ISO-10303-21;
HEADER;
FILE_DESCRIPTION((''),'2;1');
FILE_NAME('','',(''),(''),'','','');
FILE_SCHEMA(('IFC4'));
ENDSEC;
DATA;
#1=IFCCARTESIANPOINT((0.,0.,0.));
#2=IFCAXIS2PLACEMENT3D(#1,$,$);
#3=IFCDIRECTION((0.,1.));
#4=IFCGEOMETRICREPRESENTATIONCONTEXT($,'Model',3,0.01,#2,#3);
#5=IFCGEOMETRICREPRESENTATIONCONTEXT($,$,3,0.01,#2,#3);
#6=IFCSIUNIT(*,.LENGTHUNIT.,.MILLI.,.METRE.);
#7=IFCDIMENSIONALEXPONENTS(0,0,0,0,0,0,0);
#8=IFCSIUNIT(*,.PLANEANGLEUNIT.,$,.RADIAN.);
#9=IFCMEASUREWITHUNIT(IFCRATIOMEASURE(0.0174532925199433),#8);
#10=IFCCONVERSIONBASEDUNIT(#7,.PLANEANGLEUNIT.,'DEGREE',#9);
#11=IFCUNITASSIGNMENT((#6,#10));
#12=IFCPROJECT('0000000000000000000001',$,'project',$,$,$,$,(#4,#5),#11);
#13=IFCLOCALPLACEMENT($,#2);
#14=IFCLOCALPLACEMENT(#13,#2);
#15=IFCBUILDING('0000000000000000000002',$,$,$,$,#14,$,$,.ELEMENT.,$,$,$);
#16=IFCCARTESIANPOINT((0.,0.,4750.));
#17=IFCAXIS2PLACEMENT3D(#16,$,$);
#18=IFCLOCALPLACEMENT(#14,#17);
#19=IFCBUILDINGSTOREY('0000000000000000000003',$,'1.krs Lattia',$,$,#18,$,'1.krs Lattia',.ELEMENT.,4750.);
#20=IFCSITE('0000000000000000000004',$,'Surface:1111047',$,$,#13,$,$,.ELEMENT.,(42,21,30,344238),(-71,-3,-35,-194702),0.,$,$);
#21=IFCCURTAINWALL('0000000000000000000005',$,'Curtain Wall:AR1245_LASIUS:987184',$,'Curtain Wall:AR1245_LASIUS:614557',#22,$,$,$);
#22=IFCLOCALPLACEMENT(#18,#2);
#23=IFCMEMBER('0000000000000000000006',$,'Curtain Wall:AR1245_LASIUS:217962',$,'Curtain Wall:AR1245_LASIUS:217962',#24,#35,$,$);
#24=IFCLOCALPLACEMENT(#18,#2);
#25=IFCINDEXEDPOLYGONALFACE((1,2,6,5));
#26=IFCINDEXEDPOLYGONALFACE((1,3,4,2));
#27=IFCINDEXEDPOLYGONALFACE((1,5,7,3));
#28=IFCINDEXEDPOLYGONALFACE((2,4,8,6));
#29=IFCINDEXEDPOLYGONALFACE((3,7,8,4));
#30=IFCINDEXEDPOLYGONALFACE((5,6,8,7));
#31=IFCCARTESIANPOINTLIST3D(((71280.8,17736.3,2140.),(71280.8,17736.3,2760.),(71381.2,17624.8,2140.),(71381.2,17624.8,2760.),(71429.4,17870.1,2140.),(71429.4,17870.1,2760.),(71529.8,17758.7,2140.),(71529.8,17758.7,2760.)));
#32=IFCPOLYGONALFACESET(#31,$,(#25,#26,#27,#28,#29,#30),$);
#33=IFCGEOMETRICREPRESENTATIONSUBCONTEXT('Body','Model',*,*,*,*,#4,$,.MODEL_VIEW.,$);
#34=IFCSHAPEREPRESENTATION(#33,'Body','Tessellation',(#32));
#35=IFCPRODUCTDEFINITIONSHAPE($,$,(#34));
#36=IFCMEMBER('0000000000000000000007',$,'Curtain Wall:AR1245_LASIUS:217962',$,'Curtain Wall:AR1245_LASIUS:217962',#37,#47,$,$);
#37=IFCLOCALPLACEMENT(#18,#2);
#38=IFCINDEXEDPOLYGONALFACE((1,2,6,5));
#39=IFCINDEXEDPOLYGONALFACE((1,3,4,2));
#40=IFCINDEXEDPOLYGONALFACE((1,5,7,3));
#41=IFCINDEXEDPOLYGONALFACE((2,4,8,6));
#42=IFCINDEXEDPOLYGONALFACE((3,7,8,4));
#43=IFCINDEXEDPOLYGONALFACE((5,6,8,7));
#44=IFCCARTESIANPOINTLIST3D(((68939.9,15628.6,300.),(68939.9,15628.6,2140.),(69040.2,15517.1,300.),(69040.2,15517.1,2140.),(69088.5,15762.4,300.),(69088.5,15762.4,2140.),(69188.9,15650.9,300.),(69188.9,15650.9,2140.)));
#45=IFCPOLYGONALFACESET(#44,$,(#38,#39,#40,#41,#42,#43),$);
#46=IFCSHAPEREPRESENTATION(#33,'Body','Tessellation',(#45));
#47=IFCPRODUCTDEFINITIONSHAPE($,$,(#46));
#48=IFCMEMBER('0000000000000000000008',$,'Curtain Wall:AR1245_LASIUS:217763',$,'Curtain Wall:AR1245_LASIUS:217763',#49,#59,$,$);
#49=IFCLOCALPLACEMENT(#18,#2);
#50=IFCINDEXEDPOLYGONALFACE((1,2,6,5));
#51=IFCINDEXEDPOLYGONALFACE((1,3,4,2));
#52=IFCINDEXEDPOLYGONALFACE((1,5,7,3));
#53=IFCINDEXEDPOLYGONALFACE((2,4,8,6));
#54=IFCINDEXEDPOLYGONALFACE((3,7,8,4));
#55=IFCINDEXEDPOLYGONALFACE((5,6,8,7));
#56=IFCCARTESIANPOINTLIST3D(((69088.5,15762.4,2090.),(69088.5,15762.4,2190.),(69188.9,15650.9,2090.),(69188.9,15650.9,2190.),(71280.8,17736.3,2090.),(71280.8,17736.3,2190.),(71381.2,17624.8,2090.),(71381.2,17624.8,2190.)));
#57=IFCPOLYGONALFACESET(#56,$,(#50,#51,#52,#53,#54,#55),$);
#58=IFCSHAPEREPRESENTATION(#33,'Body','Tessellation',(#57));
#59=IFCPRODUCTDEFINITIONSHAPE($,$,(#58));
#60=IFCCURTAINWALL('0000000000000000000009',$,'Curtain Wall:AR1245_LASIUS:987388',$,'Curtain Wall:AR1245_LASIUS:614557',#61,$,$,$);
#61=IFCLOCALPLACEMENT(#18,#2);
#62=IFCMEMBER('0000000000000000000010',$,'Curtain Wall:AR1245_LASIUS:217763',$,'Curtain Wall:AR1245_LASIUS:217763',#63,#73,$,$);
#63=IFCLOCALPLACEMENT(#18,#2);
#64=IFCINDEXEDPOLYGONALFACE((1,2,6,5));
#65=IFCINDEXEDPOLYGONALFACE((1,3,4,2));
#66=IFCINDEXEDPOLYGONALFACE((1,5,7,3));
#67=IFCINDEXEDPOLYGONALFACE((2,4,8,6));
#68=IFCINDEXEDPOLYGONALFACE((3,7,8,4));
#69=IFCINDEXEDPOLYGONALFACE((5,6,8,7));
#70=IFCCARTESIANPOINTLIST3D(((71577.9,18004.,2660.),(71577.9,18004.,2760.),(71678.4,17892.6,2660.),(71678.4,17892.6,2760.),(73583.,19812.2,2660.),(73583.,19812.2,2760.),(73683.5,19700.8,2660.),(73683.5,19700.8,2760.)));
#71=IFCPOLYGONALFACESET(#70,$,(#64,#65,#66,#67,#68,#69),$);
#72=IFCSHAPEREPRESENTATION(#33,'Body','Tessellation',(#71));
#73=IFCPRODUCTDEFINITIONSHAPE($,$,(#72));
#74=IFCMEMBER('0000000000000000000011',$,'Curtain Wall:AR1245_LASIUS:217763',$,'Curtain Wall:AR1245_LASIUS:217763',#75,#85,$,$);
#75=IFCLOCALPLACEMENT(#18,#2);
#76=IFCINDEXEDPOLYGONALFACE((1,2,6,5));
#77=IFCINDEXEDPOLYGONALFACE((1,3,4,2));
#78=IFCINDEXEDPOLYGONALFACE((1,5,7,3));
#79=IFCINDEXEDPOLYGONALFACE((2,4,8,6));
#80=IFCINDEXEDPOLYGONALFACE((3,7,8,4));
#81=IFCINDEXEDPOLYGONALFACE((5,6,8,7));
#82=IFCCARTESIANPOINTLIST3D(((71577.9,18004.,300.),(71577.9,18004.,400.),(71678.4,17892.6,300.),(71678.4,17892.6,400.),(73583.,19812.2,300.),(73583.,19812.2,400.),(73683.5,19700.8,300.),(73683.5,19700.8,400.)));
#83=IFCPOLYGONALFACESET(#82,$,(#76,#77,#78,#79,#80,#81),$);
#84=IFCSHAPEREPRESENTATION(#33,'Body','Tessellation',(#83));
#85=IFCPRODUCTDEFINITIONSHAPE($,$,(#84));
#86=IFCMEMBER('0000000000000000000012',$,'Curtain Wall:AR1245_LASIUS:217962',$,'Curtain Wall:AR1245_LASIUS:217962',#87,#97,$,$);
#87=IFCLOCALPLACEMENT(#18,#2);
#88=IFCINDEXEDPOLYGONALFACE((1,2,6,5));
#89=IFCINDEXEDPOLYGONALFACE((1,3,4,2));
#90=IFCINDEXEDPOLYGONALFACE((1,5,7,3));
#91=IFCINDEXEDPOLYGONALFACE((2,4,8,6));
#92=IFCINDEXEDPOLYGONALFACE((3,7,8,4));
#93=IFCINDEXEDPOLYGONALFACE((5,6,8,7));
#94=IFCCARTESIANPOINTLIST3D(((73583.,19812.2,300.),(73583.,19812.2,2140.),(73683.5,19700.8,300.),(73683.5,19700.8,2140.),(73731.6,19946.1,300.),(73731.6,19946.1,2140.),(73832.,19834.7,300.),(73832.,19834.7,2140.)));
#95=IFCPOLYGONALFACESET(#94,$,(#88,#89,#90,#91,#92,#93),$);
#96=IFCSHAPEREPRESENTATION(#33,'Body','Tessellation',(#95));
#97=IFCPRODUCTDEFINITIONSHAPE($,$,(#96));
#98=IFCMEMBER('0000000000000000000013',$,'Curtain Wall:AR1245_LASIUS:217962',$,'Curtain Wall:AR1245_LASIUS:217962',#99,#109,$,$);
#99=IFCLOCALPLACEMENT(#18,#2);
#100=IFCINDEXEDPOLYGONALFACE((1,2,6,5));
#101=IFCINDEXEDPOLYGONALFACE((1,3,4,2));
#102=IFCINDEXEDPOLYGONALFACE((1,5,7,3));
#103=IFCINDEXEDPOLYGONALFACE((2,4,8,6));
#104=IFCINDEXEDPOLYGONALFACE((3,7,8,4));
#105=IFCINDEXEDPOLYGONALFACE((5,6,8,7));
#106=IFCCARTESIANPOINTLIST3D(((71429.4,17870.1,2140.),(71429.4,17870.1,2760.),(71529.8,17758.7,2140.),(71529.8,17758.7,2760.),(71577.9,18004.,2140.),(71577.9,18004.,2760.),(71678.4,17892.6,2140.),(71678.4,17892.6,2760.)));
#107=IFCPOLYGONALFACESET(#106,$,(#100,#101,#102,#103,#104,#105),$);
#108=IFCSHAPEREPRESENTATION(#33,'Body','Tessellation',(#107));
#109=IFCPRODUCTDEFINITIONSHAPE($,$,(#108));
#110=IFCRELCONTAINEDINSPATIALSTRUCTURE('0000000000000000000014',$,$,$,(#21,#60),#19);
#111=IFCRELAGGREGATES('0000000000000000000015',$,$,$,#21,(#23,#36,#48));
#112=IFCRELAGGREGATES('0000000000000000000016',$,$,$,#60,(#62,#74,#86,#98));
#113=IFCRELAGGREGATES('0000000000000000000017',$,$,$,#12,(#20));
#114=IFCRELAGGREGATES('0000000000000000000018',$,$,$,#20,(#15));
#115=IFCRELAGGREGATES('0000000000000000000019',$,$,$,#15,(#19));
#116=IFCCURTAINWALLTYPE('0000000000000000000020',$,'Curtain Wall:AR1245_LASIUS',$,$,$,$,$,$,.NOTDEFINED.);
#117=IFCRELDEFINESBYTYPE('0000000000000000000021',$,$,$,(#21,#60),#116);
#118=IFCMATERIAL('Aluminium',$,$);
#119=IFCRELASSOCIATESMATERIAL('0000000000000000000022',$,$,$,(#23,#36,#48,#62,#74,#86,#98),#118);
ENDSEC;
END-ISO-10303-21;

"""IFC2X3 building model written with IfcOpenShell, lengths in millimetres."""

from ifc_helpers import new_model, entity, si_unit, converted_unit, direction, frame, frame_2d, origin, place, context, subcontext, project, spatial, rectangle, extrude, material, type_object, element, aggregate, save


model = new_model("IFC2X3")

# Units and contexts
model_context = context("Model", 3, precision=0.01, world=origin(), true_north=direction((0.0, 1.0)))
context_of_model = context(None, 3, precision=0.01, world=origin(), true_north=direction((0.0, 1.0)))
body_context = subcontext(model_context, "Body", "Model", "MODEL_VIEW")
ifc_project = project(units=[si_unit("LENGTHUNIT", "METRE", prefix="MILLI"), converted_unit("PLANEANGLEUNIT", "DEGREE", entity("IfcRatioMeasure", 0.0174532925199433), si_unit("PLANEANGLEUNIT", "RADIAN"), dimensions=[0, 0, 0, 0, 0, 0, 0])], contexts=[model_context, context_of_model])

# Site, building, storey
site_placement = place(None, origin())
site = spatial("IfcSite", under=ifc_project, at=site_placement, Name="Surface:1111047", CompositionType="ELEMENT", RefLatitude=(42, 21, 30, 344238), RefLongitude=(-71, -3, -35, -194702), RefElevation=0.0)
building_placement = place(site_placement, origin())
building = spatial("IfcBuilding", under=site, at=building_placement, CompositionType="ELEMENT")
storey_placement = place(building_placement, frame((0.0, 0.0, 4750.0)))
storey = spatial("IfcBuildingStorey", under=building, at=storey_placement, Name="1.krs Lattia", LongName="1.krs Lattia", CompositionType="ELEMENT", Elevation=4750.0)

# Curtain walls, members
curtain_wall_type_1 = type_object("IfcCurtainWallType", Name="Curtain Wall:AR1245_LASIUS", PredefinedType="NOTDEFINED")
ifc_material_1 = material(Name="Aluminium")
curtain_wall_1_placement = place(storey_placement, frame((0.0, 0.0, -4750.0)))
curtain_wall_1 = element("IfcCurtainWall", 1, at=curtain_wall_1_placement, inside=storey, type_object=curtain_wall_type_1, Name="Curtain Wall:AR1245_LASIUS:987184", ObjectType="Curtain Wall:AR1245_LASIUS:614557")
member_1_placement = place(curtain_wall_1_placement, frame((0.0, 0.0, 4750.0)))
member_1 = element("IfcMember", 2, at=member_1_placement, material=ifc_material_1, Name="Curtain Wall:AR1245_LASIUS:217962", ObjectType="Curtain Wall:AR1245_LASIUS:217962", context=body_context, shape_type="SweptSolid", body=[
    extrude(rectangle(XDim=200.0, YDim=150.0, at=frame_2d((0.0, 0.0), x_axis=(1.0, 0.0))), frame((71405.3, 17747.5, 2140.0), z_axis=(0.0, 0.0, 1.0), x_axis=(0.743145, 0.669131, 0.0)), (0.0, 0.0, 1.0), 620.0),
])
member_2_placement = place(curtain_wall_1_placement, frame((0.0, 0.0, 4750.0)))
member_2 = element("IfcMember", 3, at=member_2_placement, material=ifc_material_1, Name="Curtain Wall:AR1245_LASIUS:217962", ObjectType="Curtain Wall:AR1245_LASIUS:217962", context=body_context, shape_type="SweptSolid", body=[
    extrude(rectangle(XDim=150.0, YDim=200.0, at=frame_2d((0.0, 0.0), x_axis=(1.0, 0.0))), frame((69064.4, 15639.7, 2140.0), z_axis=(0.0, 0.0, -1.0), x_axis=(0.669131, -0.743145, 0.0)), (0.0, 0.0, 1.0), 1840.0),
])
member_3_placement = place(curtain_wall_1_placement, frame((0.0, 0.0, 4750.0)))
member_3 = element("IfcMember", 4, at=member_3_placement, material=ifc_material_1, Name="Curtain Wall:AR1245_LASIUS:217763", ObjectType="Curtain Wall:AR1245_LASIUS:217763", context=body_context, shape_type="SweptSolid", body=[
    extrude(rectangle(XDim=100.0, YDim=150.0, at=frame_2d((0.0, 0.0), x_axis=(1.0, 0.0))), frame((71331.0, 17680.6, 2140.0), z_axis=(-0.743145, -0.669131, 0.0), x_axis=(0.0, 0.0, -1.0)), (0.0, 0.0, 1.0), 2950.0),
])
aggregate(curtain_wall_1, [member_1, member_2, member_3])
curtain_wall_2_placement = place(storey_placement, frame((0.0, 0.0, -4750.0)))
curtain_wall_2 = element("IfcCurtainWall", 5, at=curtain_wall_2_placement, inside=storey, type_object=curtain_wall_type_1, Name="Curtain Wall:AR1245_LASIUS:987388", ObjectType="Curtain Wall:AR1245_LASIUS:614557")
member_4_placement = place(curtain_wall_2_placement, frame((0.0, 0.0, 4750.0)))
member_4 = element("IfcMember", 6, at=member_4_placement, material=ifc_material_1, Name="Curtain Wall:AR1245_LASIUS:217763", ObjectType="Curtain Wall:AR1245_LASIUS:217763", context=body_context, shape_type="SweptSolid", body=[
    extrude(rectangle(XDim=100.0, YDim=150.0, at=frame_2d((0.0, 0.0), x_axis=(1.0, 0.0))), frame((73633.3, 19756.5, 2710.0), z_axis=(-0.742646, -0.669684, 0.0), x_axis=(0.0, 0.0, -1.0)), (0.0, 0.0, 1.0), 2700.0),
])
member_5_placement = place(curtain_wall_2_placement, frame((0.0, 0.0, 4750.0)))
member_5 = element("IfcMember", 7, at=member_5_placement, material=ifc_material_1, Name="Curtain Wall:AR1245_LASIUS:217763", ObjectType="Curtain Wall:AR1245_LASIUS:217763", context=body_context, shape_type="SweptSolid", body=[
    extrude(rectangle(XDim=100.0, YDim=150.0, at=frame_2d((0.0, 0.0), x_axis=(1.0, 0.0))), frame((71628.1, 17948.3, 350.0), z_axis=(0.742646, 0.669684, 0.0), x_axis=(0.0, 0.0, -1.0)), (0.0, 0.0, 1.0), 2700.0),
])
member_6_placement = place(curtain_wall_2_placement, frame((0.0, 0.0, 4750.0)))
member_6 = element("IfcMember", 8, at=member_6_placement, material=ifc_material_1, Name="Curtain Wall:AR1245_LASIUS:217962", ObjectType="Curtain Wall:AR1245_LASIUS:217962", context=body_context, shape_type="SweptSolid", body=[
    extrude(rectangle(XDim=200.0, YDim=150.0, at=frame_2d((0.0, 0.0), x_axis=(1.0, 0.0))), frame((73707.5, 19823.5, 300.0), z_axis=(0.0, 0.0, 1.0), x_axis=(0.742646, 0.669684, 0.0)), (0.0, 0.0, 1.0), 1840.0),
])
member_7_placement = place(curtain_wall_2_placement, frame((0.0, 0.0, 4750.0)))
member_7 = element("IfcMember", 9, at=member_7_placement, material=ifc_material_1, Name="Curtain Wall:AR1245_LASIUS:217962", ObjectType="Curtain Wall:AR1245_LASIUS:217962", context=body_context, shape_type="SweptSolid", body=[
    extrude(rectangle(XDim=150.0, YDim=200.0, at=frame_2d((0.0, 0.0), x_axis=(1.0, 0.0))), frame((71553.9, 17881.4, 2760.0), z_axis=(0.0, 0.0, -1.0), x_axis=(0.669684, -0.742646, 0.0)), (0.0, 0.0, 1.0), 620.0),
])
aggregate(curtain_wall_2, [member_4, member_5, member_6, member_7])

save(model, "model.ifc")
